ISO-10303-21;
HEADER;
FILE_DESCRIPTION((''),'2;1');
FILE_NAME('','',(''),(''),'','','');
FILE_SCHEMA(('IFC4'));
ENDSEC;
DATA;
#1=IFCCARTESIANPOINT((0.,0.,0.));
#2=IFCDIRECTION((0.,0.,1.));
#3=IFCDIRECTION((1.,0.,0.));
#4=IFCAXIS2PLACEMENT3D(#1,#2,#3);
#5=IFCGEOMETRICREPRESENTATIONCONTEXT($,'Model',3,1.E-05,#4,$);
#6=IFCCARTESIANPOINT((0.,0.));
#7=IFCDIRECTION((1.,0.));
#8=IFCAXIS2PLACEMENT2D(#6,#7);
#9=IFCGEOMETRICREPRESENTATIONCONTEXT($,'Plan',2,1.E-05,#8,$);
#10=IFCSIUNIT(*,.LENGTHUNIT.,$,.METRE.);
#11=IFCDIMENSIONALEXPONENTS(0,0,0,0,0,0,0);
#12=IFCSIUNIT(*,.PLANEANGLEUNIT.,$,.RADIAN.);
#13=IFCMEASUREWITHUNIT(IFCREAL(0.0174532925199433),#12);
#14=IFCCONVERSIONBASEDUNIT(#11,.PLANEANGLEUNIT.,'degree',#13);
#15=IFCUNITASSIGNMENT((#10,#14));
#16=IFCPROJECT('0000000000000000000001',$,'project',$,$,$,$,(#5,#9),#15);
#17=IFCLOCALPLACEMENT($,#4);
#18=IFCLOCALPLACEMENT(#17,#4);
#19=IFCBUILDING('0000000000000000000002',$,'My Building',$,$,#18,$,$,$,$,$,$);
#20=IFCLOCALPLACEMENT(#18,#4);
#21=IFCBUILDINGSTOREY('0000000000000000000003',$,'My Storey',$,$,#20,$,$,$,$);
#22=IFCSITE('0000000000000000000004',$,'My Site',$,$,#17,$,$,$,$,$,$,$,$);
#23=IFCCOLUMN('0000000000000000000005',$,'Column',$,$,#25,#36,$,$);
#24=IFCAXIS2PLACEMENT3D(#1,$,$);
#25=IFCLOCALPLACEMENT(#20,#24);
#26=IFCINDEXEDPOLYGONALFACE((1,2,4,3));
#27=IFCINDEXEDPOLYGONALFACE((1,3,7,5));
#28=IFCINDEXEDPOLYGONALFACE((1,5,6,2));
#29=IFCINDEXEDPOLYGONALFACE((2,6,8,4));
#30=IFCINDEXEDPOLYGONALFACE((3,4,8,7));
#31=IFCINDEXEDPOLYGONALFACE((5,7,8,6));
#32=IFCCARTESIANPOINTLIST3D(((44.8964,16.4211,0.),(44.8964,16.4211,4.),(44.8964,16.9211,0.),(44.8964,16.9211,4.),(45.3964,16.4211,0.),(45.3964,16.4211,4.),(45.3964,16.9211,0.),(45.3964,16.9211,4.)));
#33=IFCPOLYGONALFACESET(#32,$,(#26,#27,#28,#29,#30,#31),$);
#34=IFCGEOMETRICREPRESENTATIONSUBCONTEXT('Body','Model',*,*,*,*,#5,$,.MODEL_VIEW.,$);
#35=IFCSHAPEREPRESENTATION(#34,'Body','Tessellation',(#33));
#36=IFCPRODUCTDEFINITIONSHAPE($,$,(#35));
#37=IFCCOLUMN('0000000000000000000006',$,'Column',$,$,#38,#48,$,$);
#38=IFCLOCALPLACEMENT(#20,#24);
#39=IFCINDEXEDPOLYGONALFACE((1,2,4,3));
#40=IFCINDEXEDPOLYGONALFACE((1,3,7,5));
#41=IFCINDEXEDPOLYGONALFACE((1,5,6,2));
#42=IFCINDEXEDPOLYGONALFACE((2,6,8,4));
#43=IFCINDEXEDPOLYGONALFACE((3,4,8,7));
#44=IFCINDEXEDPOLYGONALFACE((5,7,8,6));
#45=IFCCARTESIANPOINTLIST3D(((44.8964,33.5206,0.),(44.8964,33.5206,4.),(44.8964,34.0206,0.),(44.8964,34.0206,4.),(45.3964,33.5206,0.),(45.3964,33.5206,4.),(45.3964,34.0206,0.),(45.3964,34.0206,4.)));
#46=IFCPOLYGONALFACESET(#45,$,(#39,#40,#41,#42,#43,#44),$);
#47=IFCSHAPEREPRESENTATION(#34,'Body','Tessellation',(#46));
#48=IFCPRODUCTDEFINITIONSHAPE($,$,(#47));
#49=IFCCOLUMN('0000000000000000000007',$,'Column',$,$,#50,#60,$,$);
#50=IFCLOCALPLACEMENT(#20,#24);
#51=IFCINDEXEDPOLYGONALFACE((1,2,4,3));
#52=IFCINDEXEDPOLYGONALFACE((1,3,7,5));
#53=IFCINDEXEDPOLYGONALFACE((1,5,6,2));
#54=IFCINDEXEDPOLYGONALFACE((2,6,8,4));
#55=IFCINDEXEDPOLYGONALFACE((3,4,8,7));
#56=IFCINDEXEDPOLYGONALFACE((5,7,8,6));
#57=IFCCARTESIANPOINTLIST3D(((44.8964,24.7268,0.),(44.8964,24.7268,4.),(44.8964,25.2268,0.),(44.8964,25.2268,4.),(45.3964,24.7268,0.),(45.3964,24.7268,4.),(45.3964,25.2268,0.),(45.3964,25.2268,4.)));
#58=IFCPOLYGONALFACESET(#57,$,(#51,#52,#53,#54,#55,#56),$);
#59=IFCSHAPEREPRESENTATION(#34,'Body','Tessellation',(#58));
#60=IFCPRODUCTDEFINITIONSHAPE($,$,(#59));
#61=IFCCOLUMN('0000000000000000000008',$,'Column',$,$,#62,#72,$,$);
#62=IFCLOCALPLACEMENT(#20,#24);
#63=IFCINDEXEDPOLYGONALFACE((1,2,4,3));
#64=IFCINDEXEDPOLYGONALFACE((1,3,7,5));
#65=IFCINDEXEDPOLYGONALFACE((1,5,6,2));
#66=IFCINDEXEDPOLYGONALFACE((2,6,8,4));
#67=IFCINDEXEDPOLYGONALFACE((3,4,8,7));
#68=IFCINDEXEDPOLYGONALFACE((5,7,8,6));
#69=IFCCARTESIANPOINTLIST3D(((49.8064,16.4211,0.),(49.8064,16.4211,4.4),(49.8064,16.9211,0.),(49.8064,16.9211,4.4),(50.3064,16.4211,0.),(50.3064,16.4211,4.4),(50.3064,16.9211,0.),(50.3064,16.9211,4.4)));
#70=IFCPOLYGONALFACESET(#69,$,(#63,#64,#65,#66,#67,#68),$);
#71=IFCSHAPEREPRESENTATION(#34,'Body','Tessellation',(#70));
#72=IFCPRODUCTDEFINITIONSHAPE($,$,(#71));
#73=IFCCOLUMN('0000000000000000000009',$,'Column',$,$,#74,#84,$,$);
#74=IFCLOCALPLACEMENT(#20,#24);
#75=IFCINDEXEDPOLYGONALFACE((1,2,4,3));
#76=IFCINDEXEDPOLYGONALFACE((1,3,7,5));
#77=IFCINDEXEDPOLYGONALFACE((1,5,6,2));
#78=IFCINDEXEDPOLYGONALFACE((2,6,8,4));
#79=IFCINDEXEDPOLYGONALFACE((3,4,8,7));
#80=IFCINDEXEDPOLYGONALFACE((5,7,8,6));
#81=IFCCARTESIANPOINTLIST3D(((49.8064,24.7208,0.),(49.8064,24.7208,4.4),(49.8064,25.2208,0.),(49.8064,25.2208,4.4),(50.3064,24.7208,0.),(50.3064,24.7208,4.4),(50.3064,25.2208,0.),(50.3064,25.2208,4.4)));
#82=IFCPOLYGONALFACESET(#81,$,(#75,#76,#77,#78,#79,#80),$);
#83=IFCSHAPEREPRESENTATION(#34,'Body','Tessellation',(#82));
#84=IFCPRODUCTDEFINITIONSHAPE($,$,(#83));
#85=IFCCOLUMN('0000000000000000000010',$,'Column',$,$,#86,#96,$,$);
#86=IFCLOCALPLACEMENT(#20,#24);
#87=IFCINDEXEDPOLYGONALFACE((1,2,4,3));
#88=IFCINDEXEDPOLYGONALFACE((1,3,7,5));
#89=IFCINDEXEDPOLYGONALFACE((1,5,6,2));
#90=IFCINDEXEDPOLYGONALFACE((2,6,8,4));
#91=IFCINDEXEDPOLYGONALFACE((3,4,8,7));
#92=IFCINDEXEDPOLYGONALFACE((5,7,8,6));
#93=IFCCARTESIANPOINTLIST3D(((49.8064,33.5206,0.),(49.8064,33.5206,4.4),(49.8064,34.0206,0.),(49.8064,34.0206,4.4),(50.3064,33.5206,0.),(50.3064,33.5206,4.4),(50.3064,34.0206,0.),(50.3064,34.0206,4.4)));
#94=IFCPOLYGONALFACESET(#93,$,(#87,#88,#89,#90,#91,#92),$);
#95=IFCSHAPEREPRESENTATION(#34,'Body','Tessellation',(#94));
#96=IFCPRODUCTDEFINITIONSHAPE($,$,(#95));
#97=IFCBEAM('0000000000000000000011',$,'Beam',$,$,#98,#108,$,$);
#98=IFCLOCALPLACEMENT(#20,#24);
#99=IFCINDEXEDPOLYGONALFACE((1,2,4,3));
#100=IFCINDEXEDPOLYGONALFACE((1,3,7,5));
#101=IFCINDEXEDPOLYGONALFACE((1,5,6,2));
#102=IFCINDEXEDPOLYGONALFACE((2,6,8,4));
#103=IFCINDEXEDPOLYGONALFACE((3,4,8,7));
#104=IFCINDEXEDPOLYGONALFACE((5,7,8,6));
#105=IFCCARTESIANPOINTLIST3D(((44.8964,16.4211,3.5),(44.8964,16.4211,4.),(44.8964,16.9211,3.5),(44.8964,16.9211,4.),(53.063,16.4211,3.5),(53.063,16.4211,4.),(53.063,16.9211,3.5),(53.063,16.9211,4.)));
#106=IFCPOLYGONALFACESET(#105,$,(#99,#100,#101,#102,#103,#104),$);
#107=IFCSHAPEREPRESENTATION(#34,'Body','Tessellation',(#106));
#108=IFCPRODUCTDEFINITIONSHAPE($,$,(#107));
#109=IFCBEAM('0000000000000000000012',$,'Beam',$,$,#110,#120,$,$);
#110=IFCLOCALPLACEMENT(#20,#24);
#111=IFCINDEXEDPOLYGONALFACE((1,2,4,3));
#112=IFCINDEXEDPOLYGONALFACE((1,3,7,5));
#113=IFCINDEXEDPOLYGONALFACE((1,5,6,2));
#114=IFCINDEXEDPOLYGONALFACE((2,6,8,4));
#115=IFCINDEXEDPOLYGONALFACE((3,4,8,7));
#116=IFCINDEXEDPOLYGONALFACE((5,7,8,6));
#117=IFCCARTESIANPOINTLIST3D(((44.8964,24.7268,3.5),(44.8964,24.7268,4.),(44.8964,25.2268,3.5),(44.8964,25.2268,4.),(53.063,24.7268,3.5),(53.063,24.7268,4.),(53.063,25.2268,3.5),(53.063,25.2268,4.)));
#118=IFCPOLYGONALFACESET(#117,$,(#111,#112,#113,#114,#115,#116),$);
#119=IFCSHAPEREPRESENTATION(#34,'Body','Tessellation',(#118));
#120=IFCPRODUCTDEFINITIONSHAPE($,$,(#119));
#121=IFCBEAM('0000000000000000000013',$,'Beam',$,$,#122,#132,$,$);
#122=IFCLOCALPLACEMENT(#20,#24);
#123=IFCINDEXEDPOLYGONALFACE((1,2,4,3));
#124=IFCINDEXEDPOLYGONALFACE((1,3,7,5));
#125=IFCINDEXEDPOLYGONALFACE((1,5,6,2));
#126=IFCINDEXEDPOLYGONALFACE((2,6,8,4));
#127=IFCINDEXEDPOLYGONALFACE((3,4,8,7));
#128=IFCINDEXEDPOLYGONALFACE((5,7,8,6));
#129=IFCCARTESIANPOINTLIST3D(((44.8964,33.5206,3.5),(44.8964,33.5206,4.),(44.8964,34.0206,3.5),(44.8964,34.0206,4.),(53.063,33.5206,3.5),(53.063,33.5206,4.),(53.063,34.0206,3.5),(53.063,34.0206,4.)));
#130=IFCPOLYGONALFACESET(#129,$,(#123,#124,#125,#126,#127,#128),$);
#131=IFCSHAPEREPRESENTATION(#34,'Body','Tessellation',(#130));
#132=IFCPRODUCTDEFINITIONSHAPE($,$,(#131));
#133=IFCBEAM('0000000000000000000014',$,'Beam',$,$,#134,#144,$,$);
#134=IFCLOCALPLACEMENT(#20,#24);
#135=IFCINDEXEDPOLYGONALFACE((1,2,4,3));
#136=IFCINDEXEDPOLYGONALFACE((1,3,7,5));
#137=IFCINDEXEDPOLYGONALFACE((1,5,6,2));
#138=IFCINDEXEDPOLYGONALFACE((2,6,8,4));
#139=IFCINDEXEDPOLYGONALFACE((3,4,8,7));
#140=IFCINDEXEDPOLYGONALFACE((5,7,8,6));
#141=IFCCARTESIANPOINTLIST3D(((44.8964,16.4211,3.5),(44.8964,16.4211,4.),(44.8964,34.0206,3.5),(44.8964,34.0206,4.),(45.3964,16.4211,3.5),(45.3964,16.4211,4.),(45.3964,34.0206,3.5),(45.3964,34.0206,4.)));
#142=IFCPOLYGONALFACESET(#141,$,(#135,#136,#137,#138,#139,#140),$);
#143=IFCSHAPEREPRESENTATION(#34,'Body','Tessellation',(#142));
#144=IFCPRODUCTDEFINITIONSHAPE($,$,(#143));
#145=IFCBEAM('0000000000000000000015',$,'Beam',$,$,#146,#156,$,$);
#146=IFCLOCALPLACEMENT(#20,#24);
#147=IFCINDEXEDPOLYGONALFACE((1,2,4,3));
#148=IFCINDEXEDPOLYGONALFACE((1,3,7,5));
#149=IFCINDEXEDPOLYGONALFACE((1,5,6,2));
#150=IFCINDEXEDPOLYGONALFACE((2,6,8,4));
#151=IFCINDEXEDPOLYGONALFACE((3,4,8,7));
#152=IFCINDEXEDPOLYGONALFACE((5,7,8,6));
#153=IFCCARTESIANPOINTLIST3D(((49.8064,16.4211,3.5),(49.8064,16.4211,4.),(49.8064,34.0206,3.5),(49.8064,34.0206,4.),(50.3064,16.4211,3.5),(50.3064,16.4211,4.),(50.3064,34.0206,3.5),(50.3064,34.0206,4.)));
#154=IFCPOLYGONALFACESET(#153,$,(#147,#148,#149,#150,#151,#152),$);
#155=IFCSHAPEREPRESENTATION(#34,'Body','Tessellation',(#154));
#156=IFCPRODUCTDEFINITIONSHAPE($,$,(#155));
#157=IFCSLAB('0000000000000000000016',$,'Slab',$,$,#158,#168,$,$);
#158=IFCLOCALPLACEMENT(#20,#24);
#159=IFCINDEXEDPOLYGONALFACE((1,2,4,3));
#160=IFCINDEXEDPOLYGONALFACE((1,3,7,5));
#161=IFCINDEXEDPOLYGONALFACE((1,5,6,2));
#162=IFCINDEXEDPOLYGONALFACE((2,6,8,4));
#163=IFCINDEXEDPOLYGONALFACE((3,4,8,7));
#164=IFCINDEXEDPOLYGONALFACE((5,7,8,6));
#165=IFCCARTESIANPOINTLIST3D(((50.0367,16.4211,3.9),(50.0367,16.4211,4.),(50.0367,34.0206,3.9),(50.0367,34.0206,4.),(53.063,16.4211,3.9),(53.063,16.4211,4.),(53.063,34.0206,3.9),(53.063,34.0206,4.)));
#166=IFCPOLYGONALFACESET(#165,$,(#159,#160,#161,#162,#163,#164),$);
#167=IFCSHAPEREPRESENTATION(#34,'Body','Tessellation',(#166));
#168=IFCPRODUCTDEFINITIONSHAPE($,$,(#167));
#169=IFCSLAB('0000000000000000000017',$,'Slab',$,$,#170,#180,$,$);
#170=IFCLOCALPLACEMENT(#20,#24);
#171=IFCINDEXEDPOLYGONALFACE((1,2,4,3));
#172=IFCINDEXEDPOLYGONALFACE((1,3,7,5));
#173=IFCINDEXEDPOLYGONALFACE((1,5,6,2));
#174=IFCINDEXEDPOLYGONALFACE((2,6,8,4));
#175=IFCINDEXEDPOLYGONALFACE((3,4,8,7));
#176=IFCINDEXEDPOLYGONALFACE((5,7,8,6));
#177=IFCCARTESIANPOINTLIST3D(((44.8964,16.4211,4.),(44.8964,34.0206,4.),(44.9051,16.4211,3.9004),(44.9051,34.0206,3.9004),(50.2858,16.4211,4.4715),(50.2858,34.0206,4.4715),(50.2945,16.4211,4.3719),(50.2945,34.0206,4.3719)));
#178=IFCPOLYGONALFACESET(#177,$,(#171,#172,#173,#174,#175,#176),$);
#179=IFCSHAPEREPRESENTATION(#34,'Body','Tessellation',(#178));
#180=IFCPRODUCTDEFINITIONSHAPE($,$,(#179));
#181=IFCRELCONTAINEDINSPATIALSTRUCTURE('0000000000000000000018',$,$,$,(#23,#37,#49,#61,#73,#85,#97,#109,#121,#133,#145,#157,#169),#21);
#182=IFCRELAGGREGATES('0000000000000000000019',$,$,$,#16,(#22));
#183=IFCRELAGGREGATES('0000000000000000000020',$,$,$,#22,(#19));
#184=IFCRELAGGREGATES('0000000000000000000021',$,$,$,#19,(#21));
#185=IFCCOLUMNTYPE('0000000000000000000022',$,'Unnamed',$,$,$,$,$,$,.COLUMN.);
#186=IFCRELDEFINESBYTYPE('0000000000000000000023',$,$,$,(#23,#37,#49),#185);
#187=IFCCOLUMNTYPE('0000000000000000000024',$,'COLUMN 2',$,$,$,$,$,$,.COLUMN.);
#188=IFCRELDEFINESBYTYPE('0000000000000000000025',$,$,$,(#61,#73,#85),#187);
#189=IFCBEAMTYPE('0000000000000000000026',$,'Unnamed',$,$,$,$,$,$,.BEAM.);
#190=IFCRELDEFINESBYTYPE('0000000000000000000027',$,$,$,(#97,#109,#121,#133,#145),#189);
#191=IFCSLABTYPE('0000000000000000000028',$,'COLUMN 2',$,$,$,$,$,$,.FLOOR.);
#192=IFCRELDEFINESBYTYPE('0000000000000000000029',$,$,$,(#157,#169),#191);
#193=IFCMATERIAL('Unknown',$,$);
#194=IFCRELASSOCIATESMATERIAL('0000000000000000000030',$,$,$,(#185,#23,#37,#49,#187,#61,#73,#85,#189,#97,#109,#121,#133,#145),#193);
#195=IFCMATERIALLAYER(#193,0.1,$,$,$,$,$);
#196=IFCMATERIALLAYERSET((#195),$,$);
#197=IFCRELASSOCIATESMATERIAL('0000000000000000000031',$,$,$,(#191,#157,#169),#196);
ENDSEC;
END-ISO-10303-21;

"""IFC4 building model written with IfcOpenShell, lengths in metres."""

from ifc_helpers import new_model, entity, si_unit, converted_unit, frame, origin_with_axes, origin_2d_with_axis, place, context, subcontext, project, spatial, indexed_curve, rectangle, outline, extrude, material, layer, layer_set, layer_usage, material_profile, profile_set, profile_usage, type_object, element, save


model = new_model("IFC4")

# Units and contexts
model_context = context("Model", 3, precision=1e-05, world=origin_with_axes())
plan_context = context("Plan", 2, precision=1e-05, world=origin_2d_with_axis())
body_context = subcontext(model_context, "Body", "Model", "MODEL_VIEW")
ifc_project = project(units=[si_unit("LENGTHUNIT", "METRE"), converted_unit("PLANEANGLEUNIT", "degree", entity("IfcReal", 0.0174532925199433), si_unit("PLANEANGLEUNIT", "RADIAN"), dimensions=[0, 0, 0, 0, 0, 0, 0])], contexts=[model_context, plan_context])

# Site, building, storey
site_placement = place(None, origin_with_axes())
site = spatial("IfcSite", under=ifc_project, at=site_placement, Name="My Site")
building_placement = place(site_placement, origin_with_axes())
building = spatial("IfcBuilding", under=site, at=building_placement, Name="My Building")
storey_placement = place(building_placement, origin_with_axes())
storey = spatial("IfcBuildingStorey", under=building, at=storey_placement, Name="My Storey")

# Columns
ifc_material = material(Name="Unknown")
ifc_material_profile_1 = material_profile(ifc_material, rectangle(XDim=0.5, YDim=0.5))
ifc_profile_set_1 = profile_set([ifc_material_profile_1])
ifc_profile_usage_1 = profile_usage(ifc_profile_set_1, cardinal=3)
column_type_1 = type_object("IfcColumnType", Name="Unnamed", PredefinedType="COLUMN", material=ifc_profile_set_1)
column_1_placement = place(storey_placement, frame((44.8964, 16.4211, 0.0), z_axis=(0.0, 0.0, 1.0), x_axis=(1.0, 0.0, 0.0)))
element("IfcColumn", 1, at=column_1_placement, inside=storey, type_object=column_type_1, material=ifc_profile_usage_1, Name="Column", context=body_context, shape_type="SweptSolid", body=[
    extrude(rectangle(XDim=0.5, YDim=0.5), frame((0.25, 0.25, 0.0), z_axis=(0.0, 0.0, 1.0), x_axis=(1.0, 0.0, 0.0)), (0.0, 0.0, 1.0), 4.0),
])
ifc_profile_usage_2 = profile_usage(ifc_profile_set_1, cardinal=3)
column_2_placement = place(storey_placement, frame((44.8964, 33.5206, 0.0), z_axis=(0.0, 0.0, 1.0), x_axis=(1.0, 0.0, 0.0)))
element("IfcColumn", 2, at=column_2_placement, inside=storey, type_object=column_type_1, material=ifc_profile_usage_2, Name="Column", context=body_context, shape_type="SweptSolid", body=[
    extrude(rectangle(XDim=0.5, YDim=0.5), frame((0.25, 0.25, 0.0), z_axis=(0.0, 0.0, 1.0), x_axis=(1.0, 0.0, 0.0)), (0.0, 0.0, 1.0), 4.0),
])
ifc_profile_usage_3 = profile_usage(ifc_profile_set_1, cardinal=3)
column_3_placement = place(storey_placement, frame((44.8964, 24.7268, 0.0), z_axis=(0.0, 0.0, 1.0), x_axis=(1.0, 0.0, 0.0)))
element("IfcColumn", 3, at=column_3_placement, inside=storey, type_object=column_type_1, material=ifc_profile_usage_3, Name="Column", context=body_context, shape_type="SweptSolid", body=[
    extrude(rectangle(XDim=0.5, YDim=0.5), frame((0.25, 0.25, 0.0), z_axis=(0.0, 0.0, 1.0), x_axis=(1.0, 0.0, 0.0)), (0.0, 0.0, 1.0), 4.0),
])
ifc_material_profile_2 = material_profile(ifc_material, rectangle(XDim=0.5, YDim=0.5))
ifc_profile_set_2 = profile_set([ifc_material_profile_2])
ifc_profile_usage_4 = profile_usage(ifc_profile_set_2, cardinal=3)
column_type_2 = type_object("IfcColumnType", Name="COLUMN 2", PredefinedType="COLUMN", material=ifc_profile_set_2)
column_4_placement = place(storey_placement, frame((49.8064, 16.4211, 0.0), z_axis=(0.0, 0.0, 1.0), x_axis=(1.0, 0.0, 0.0)))
element("IfcColumn", 4, at=column_4_placement, inside=storey, type_object=column_type_2, material=ifc_profile_usage_4, Name="Column", context=body_context, shape_type="SweptSolid", body=[
    extrude(rectangle(XDim=0.5, YDim=0.5), frame((0.25, 0.25, 0.0), z_axis=(0.0, 0.0, 1.0), x_axis=(1.0, 0.0, 0.0)), (0.0, 0.0, 1.0), 4.4),
])
ifc_profile_usage_5 = profile_usage(ifc_profile_set_2, cardinal=3)
column_5_placement = place(storey_placement, frame((49.8064, 24.7208, 0.0), z_axis=(0.0, 0.0, 1.0), x_axis=(1.0, 0.0, 0.0)))
element("IfcColumn", 5, at=column_5_placement, inside=storey, type_object=column_type_2, material=ifc_profile_usage_5, Name="Column", context=body_context, shape_type="SweptSolid", body=[
    extrude(rectangle(XDim=0.5, YDim=0.5), frame((0.25, 0.25, 0.0), z_axis=(0.0, 0.0, 1.0), x_axis=(1.0, 0.0, 0.0)), (0.0, 0.0, 1.0), 4.4),
])
ifc_profile_usage_6 = profile_usage(ifc_profile_set_2, cardinal=3)
column_6_placement = place(storey_placement, frame((49.8064, 33.5206, 0.0), z_axis=(0.0, 0.0, 1.0), x_axis=(1.0, 0.0, 0.0)))
element("IfcColumn", 6, at=column_6_placement, inside=storey, type_object=column_type_2, material=ifc_profile_usage_6, Name="Column", context=body_context, shape_type="SweptSolid", body=[
    extrude(rectangle(XDim=0.5, YDim=0.5), frame((0.25, 0.25, 0.0), z_axis=(0.0, 0.0, 1.0), x_axis=(1.0, 0.0, 0.0)), (0.0, 0.0, 1.0), 4.4),
])

# Beams
ifc_material_profile_3 = material_profile(ifc_material, rectangle(XDim=0.5, YDim=0.5))
ifc_profile_set_3 = profile_set([ifc_material_profile_3])
ifc_profile_usage_7 = profile_usage(ifc_profile_set_3, cardinal=3)
beam_type = type_object("IfcBeamType", Name="Unnamed", PredefinedType="BEAM", material=ifc_profile_set_3)
beam_1_placement = place(storey_placement, frame((44.8964, 16.4211, 3.5), z_axis=(1.0, 0.0, 0.0), x_axis=(0.0, 1.0, 0.0)))
element("IfcBeam", 7, at=beam_1_placement, inside=storey, type_object=beam_type, material=ifc_profile_usage_7, Name="Beam", context=body_context, shape_type="SweptSolid", body=[
    extrude(rectangle(XDim=0.5, YDim=0.5), frame((0.25, 0.25, 0.0), z_axis=(0.0, 0.0, 1.0), x_axis=(1.0, 0.0, 0.0)), (0.0, 0.0, 1.0), 8.1666),
])
ifc_profile_usage_8 = profile_usage(ifc_profile_set_3, cardinal=3)
beam_2_placement = place(storey_placement, frame((44.8964, 24.7268, 3.5), z_axis=(1.0, 0.0, 0.0), x_axis=(0.0, 1.0, 0.0)))
element("IfcBeam", 8, at=beam_2_placement, inside=storey, type_object=beam_type, material=ifc_profile_usage_8, Name="Beam", context=body_context, shape_type="SweptSolid", body=[
    extrude(rectangle(XDim=0.5, YDim=0.5), frame((0.25, 0.25, 0.0), z_axis=(0.0, 0.0, 1.0), x_axis=(1.0, 0.0, 0.0)), (0.0, 0.0, 1.0), 8.1666),
])
ifc_profile_usage_9 = profile_usage(ifc_profile_set_3, cardinal=3)
beam_3_placement = place(storey_placement, frame((44.8964, 33.5206, 3.5), z_axis=(1.0, 0.0, 0.0), x_axis=(0.0, 1.0, 0.0)))
element("IfcBeam", 9, at=beam_3_placement, inside=storey, type_object=beam_type, material=ifc_profile_usage_9, Name="Beam", context=body_context, shape_type="SweptSolid", body=[
    extrude(rectangle(XDim=0.5, YDim=0.5), frame((0.25, 0.25, 0.0), z_axis=(0.0, 0.0, 1.0), x_axis=(1.0, 0.0, 0.0)), (0.0, 0.0, 1.0), 8.1666),
])
ifc_profile_usage_10 = profile_usage(ifc_profile_set_3, cardinal=3)
beam_4_placement = place(storey_placement, frame((44.8964, 34.0206, 3.5), z_axis=(0.0, -1.0, 0.0), x_axis=(1.0, 0.0, 0.0)))
element("IfcBeam", 10, at=beam_4_placement, inside=storey, type_object=beam_type, material=ifc_profile_usage_10, Name="Beam", context=body_context, shape_type="SweptSolid", body=[
    extrude(rectangle(XDim=0.5, YDim=0.5), frame((0.25, 0.25, 0.0), z_axis=(0.0, 0.0, 1.0), x_axis=(1.0, 0.0, 0.0)), (0.0, 0.0, 1.0), 17.5994),
])
ifc_profile_usage_11 = profile_usage(ifc_profile_set_3, cardinal=3)
beam_5_placement = place(storey_placement, frame((49.8064, 34.0206, 3.5), z_axis=(0.0, -1.0, 0.0), x_axis=(1.0, 0.0, 0.0)))
element("IfcBeam", 11, at=beam_5_placement, inside=storey, type_object=beam_type, material=ifc_profile_usage_11, Name="Beam", context=body_context, shape_type="SweptSolid", body=[
    extrude(rectangle(XDim=0.5, YDim=0.5), frame((0.25, 0.25, 0.0), z_axis=(0.0, 0.0, 1.0), x_axis=(1.0, 0.0, 0.0)), (0.0, 0.0, 1.0), 17.5994),
])

# Slabs
ifc_layer_1 = layer(ifc_material, 0.1)
ifc_layer_set_1 = layer_set([ifc_layer_1])
ifc_layer_usage_1 = layer_usage(ifc_layer_set_1, "AXIS3", "POSITIVE", -0.1)
slab_type = type_object("IfcSlabType", Name="COLUMN 2", PredefinedType="FLOOR", material=ifc_layer_set_1)
slab_1_placement = place(storey_placement, frame((53.063, 16.4211, 4.0), z_axis=(0.0, 0.0, 1.0), x_axis=(1.0, 0.0, 0.0)))
element("IfcSlab", 12, at=slab_1_placement, inside=storey, type_object=slab_type, material=ifc_layer_usage_1, Name="Slab", context=body_context, shape_type="SweptSolid", body=[
    extrude(outline(indexed_curve([(0.0, 0.0), (-3.0263, 0.0), (-3.0263, 17.5994), (0.0, 17.5994), (0.0, 0.0)])), frame((0.0, 0.0, -0.1), z_axis=(0.0, 0.0, 1.0), x_axis=(1.0, 0.0, 0.0)), (0.0, 0.0, 1.0), 0.1),
])
ifc_layer_usage_2 = layer_usage(ifc_layer_set_1, "AXIS3", "POSITIVE", -0.1)
slab_2_placement = place(storey_placement, frame((44.8964, 34.0206, 4.0), z_axis=(-0.087156, 0.0, 0.996195), x_axis=(0.996195, 0.0, 0.087156)))
element("IfcSlab", 13, at=slab_2_placement, inside=storey, type_object=slab_type, material=ifc_layer_usage_2, Name="Slab", context=body_context, shape_type="SweptSolid", body=[
    extrude(outline(indexed_curve([(0.0, 0.0), (0.0, -17.5994), (5.4099, -17.5994), (5.4099, 0.0), (0.0, 0.0)])), frame((0.0, 0.0, -0.1), z_axis=(0.0, 0.0, 1.0), x_axis=(1.0, 0.0, 0.0)), (0.0, 0.0, 1.0), 0.1),
])

save(model, "model.ifc")
